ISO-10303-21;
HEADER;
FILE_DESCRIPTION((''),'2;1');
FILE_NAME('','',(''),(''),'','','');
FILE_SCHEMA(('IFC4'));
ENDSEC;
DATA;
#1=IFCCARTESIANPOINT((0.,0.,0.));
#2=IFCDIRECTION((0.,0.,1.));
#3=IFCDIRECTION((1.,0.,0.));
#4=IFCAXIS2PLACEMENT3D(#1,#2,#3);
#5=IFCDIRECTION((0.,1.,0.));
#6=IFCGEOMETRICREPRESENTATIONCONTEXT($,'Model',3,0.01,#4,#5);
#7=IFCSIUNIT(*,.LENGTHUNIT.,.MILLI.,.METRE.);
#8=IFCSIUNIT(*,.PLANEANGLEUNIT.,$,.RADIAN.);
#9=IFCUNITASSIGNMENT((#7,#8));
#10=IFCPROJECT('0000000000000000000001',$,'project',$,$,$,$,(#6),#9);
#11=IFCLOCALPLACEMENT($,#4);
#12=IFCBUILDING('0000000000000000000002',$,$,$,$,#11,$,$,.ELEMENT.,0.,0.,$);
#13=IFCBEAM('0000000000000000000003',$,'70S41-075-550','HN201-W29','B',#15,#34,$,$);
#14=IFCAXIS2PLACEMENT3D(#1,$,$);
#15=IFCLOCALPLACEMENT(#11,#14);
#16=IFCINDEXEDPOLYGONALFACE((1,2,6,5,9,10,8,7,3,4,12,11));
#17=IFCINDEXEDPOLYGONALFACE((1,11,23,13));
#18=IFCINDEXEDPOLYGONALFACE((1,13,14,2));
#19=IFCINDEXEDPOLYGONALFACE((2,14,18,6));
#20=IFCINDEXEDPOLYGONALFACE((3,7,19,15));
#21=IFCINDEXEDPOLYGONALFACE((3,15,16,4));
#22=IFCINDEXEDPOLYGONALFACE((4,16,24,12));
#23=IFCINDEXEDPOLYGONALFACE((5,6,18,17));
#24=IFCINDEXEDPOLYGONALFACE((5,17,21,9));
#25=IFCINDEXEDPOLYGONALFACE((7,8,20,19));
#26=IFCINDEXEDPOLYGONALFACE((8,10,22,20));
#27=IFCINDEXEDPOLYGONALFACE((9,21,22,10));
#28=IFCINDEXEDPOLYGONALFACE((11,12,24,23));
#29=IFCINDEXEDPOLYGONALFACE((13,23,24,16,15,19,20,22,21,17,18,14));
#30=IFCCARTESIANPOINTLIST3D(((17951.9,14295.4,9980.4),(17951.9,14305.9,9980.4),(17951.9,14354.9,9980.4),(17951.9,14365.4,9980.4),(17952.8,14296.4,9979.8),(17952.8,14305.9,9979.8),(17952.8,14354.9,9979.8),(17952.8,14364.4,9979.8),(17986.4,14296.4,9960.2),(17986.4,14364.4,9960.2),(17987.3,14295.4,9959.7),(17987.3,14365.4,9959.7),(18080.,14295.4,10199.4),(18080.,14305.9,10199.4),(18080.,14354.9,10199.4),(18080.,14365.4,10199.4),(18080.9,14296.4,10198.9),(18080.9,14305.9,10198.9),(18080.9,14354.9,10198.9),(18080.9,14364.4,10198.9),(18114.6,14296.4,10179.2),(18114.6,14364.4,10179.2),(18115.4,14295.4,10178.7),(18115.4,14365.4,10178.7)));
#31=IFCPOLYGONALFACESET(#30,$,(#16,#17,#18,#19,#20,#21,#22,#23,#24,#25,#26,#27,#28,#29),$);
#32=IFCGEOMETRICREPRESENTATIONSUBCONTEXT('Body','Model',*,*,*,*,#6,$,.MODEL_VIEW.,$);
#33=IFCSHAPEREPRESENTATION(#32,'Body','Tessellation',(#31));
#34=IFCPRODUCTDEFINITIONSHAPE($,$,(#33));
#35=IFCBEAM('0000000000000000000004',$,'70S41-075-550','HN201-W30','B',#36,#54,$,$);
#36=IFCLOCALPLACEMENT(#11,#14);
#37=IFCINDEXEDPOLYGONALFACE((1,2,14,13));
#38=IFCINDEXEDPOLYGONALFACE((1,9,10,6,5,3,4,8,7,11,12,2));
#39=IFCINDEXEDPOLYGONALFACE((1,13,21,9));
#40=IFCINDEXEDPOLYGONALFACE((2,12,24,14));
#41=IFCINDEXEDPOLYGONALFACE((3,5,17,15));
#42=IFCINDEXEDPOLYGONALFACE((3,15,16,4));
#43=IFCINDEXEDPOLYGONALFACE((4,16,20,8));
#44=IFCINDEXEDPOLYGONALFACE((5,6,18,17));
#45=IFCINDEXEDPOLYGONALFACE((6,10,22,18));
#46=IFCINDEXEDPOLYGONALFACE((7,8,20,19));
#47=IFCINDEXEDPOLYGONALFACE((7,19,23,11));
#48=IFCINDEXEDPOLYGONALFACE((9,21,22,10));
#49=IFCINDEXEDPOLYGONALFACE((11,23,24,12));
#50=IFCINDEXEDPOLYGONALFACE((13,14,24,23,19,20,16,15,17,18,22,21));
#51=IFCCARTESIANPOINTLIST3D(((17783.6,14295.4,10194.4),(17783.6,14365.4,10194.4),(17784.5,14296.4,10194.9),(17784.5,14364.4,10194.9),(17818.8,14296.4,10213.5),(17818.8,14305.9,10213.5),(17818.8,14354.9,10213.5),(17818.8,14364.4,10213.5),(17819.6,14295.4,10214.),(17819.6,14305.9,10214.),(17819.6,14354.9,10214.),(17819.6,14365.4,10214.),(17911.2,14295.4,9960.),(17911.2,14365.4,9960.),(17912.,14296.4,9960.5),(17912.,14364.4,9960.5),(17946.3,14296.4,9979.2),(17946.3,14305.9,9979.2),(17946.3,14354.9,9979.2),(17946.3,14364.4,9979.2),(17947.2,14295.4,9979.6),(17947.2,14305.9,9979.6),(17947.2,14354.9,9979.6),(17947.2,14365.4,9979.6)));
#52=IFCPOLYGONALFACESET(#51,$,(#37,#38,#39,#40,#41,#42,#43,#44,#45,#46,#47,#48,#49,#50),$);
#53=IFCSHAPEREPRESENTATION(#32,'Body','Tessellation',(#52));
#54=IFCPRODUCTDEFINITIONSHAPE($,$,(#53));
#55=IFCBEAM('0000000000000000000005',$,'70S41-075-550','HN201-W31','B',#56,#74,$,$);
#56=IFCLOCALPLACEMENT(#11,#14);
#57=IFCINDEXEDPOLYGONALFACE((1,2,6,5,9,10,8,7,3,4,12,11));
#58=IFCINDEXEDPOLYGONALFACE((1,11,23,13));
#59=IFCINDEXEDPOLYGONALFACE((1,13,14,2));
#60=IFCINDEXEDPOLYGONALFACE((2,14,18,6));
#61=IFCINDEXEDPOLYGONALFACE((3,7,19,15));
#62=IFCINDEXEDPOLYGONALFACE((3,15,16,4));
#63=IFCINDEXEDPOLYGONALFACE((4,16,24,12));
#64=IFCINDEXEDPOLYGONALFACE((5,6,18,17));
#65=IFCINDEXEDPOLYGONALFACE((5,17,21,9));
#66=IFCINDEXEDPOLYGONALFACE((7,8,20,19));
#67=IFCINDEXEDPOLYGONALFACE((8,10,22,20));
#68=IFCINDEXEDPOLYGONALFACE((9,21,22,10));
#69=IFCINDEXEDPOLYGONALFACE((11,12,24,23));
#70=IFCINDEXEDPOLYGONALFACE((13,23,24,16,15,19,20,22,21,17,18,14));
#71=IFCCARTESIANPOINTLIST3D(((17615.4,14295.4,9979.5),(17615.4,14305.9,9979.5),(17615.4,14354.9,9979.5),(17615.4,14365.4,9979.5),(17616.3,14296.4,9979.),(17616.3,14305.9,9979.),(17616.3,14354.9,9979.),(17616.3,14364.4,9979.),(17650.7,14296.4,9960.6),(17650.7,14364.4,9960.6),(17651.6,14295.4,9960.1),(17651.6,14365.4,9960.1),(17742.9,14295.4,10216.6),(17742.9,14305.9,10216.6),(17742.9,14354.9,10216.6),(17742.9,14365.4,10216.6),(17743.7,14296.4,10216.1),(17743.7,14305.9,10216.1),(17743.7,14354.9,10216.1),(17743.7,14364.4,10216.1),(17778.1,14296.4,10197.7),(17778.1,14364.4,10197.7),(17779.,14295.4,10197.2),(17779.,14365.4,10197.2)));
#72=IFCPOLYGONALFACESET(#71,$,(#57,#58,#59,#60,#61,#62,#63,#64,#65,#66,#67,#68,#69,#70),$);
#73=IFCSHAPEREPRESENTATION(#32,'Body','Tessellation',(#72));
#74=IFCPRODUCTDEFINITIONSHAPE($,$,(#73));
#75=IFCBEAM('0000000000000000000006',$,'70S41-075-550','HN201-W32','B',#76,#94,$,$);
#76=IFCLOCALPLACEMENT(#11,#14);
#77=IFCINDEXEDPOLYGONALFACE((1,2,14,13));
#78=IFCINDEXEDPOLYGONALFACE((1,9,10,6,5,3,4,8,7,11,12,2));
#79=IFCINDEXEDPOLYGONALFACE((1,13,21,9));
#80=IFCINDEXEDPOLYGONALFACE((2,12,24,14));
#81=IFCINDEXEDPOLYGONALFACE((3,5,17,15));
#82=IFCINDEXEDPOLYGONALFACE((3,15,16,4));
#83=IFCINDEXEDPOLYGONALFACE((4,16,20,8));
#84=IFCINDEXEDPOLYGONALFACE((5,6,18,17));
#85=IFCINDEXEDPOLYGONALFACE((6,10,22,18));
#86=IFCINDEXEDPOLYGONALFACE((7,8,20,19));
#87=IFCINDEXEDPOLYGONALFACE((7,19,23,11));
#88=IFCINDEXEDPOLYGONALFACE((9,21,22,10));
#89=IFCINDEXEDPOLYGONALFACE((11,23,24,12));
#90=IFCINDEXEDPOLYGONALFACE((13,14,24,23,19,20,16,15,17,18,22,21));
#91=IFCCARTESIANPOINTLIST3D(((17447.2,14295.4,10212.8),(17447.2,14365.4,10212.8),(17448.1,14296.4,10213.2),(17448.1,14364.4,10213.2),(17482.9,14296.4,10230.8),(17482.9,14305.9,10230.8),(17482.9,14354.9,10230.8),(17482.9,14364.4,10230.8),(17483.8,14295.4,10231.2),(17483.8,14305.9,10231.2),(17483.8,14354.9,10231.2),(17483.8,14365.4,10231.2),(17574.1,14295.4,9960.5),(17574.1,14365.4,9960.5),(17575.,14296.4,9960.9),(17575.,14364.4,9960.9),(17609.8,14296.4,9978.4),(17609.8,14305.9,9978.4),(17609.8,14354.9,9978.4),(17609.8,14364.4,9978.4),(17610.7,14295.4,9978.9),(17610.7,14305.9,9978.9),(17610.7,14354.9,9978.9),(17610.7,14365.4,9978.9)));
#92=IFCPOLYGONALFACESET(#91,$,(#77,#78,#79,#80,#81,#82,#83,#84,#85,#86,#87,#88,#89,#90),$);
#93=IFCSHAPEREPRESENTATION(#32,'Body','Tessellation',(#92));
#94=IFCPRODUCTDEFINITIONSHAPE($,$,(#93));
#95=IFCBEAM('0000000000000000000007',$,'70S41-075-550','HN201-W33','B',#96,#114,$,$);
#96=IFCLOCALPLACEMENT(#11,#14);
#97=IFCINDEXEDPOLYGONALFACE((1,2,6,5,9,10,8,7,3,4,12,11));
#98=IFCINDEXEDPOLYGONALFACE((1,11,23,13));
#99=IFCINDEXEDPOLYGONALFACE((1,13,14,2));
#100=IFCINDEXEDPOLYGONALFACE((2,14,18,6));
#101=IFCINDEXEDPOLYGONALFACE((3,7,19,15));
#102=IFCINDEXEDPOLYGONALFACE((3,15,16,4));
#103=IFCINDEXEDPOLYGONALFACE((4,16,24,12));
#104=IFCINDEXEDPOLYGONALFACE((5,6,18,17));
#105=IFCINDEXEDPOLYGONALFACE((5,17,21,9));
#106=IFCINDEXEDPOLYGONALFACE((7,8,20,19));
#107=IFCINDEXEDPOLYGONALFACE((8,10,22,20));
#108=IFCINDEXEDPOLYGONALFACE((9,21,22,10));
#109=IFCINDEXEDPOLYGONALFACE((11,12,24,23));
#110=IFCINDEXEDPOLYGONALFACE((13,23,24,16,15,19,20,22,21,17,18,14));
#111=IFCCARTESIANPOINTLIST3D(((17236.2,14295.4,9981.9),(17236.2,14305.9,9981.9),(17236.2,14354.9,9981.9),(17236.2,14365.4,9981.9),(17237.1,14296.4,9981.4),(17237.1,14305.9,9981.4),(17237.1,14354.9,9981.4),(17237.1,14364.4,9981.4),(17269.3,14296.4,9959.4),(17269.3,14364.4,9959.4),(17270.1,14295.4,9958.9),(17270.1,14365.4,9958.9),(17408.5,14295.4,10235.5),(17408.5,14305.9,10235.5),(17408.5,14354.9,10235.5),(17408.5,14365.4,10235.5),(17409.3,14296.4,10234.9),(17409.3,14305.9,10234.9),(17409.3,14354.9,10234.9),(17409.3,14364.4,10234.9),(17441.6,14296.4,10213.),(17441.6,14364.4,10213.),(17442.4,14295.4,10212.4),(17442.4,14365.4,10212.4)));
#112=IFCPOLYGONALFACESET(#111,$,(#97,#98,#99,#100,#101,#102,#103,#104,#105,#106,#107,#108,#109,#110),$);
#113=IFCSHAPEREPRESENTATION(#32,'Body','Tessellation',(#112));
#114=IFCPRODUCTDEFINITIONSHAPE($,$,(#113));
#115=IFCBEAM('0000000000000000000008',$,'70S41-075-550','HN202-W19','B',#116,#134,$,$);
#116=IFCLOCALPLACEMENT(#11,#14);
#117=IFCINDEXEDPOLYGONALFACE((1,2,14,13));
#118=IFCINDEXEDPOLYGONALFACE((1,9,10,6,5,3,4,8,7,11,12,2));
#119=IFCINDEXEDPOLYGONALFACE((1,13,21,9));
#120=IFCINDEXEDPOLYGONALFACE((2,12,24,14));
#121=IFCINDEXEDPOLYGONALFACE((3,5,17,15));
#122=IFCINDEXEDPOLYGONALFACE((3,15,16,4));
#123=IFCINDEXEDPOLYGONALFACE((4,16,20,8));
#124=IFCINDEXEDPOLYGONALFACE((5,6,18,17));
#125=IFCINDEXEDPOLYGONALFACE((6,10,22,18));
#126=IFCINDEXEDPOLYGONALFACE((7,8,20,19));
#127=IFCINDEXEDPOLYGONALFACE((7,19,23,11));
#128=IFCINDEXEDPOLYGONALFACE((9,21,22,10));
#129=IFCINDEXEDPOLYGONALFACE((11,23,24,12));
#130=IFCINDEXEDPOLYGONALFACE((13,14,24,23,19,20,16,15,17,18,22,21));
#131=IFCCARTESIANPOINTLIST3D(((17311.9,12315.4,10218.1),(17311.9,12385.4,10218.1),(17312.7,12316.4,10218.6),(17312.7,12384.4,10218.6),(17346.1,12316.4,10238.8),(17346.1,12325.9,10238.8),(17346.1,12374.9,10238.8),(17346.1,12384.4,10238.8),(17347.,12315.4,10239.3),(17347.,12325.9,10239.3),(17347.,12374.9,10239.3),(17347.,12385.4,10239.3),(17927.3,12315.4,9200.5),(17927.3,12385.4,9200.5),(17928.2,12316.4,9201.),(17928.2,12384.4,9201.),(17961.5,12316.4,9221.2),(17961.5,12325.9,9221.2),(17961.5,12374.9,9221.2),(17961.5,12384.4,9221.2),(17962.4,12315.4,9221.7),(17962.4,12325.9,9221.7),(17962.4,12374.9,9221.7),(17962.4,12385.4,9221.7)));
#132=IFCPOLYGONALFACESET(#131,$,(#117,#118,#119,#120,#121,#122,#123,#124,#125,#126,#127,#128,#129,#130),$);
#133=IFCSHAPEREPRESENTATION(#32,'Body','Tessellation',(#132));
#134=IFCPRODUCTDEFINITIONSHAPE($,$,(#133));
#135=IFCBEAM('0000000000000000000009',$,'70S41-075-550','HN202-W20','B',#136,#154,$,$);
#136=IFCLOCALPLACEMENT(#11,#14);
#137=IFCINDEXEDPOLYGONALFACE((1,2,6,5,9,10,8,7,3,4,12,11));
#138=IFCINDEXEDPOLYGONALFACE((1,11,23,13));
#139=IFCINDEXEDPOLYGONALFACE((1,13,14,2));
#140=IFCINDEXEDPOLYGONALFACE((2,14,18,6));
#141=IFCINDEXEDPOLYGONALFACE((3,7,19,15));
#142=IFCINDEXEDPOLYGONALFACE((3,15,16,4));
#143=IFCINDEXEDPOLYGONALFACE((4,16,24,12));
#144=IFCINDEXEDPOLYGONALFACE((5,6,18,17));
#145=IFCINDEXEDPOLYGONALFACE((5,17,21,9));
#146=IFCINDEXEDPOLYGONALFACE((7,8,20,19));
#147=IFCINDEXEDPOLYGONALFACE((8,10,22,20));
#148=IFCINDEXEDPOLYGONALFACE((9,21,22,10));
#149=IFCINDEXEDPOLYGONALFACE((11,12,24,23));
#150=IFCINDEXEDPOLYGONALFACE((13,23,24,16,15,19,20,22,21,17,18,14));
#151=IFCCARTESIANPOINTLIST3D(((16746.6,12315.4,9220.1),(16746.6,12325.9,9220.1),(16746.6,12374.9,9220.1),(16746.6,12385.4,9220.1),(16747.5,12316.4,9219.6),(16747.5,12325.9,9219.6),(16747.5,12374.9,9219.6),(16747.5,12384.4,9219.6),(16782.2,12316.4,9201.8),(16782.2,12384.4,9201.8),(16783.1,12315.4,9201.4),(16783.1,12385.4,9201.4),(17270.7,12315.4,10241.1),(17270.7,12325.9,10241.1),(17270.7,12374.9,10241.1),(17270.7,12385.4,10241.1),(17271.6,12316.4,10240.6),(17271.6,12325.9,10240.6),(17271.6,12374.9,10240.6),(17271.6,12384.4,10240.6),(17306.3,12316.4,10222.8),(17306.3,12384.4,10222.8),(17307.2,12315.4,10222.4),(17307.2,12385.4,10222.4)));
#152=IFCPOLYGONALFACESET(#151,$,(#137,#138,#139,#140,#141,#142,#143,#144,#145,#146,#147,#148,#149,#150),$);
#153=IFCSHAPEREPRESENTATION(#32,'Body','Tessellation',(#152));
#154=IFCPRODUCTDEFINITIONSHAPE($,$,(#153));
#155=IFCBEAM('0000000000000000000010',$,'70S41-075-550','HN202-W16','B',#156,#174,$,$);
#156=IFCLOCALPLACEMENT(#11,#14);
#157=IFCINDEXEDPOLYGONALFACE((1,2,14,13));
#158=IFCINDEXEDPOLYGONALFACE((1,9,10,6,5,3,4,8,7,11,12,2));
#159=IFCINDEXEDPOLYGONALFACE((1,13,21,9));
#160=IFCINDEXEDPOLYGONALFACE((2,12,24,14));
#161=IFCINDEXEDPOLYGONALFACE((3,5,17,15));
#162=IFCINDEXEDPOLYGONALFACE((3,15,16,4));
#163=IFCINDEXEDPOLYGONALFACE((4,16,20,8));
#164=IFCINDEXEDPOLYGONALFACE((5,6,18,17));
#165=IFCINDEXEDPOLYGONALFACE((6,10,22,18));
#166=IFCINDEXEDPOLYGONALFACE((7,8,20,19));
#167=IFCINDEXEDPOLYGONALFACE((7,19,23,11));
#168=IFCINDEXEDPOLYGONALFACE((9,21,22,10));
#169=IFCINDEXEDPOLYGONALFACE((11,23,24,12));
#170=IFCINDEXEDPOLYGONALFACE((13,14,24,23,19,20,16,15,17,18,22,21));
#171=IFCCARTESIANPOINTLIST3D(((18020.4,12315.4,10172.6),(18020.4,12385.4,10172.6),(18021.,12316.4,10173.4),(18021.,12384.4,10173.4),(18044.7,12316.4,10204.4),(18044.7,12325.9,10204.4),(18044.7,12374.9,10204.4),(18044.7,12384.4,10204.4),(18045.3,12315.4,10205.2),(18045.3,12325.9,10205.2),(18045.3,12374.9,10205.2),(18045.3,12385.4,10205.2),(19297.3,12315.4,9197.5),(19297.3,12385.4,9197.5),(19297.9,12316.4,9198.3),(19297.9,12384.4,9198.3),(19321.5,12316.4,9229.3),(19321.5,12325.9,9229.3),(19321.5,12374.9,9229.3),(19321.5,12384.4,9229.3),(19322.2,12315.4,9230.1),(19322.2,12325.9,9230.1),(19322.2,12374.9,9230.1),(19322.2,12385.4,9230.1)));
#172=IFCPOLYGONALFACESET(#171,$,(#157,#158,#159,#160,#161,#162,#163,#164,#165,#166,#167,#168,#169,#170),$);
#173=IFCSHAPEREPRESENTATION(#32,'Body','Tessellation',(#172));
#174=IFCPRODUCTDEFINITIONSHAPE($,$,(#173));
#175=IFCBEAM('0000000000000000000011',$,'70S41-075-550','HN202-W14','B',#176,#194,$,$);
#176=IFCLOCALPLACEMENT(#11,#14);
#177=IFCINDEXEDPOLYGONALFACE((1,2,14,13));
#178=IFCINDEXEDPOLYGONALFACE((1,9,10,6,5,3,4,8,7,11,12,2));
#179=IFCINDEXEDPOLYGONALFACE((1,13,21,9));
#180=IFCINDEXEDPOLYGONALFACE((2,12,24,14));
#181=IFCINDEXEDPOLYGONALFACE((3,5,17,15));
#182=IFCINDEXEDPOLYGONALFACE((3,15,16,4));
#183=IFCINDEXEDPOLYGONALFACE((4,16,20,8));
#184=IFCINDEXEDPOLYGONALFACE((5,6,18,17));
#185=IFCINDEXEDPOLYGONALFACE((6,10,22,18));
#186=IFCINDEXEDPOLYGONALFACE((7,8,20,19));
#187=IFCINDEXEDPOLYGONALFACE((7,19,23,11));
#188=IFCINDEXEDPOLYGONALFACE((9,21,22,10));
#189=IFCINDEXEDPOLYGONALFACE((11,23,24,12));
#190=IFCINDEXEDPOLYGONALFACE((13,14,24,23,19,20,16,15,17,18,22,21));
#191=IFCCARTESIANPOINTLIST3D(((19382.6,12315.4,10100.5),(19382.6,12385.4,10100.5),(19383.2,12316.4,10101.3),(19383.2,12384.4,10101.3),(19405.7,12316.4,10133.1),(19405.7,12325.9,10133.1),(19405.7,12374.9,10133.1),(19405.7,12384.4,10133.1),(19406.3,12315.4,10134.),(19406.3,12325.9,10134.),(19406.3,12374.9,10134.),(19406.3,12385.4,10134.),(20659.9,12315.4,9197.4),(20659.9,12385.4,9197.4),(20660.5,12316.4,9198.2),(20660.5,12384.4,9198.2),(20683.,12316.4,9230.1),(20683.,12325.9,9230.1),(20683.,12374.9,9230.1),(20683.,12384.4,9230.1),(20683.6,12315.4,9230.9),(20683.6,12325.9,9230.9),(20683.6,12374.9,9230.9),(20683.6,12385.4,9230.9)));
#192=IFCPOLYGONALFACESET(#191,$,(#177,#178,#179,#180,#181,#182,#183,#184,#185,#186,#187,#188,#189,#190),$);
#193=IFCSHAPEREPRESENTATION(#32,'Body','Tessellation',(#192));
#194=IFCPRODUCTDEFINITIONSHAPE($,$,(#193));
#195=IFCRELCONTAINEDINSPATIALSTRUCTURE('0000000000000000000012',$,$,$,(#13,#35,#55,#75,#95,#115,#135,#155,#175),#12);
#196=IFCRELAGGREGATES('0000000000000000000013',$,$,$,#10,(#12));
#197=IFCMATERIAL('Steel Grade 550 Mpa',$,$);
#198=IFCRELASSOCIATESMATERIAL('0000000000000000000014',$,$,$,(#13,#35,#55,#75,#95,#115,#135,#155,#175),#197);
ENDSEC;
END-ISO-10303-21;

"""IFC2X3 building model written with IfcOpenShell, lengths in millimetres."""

from ifc_helpers import new_model, si_unit, direction, frame, origin, origin_with_axes, origin_2d_with_axis, place, context, subcontext, project, spatial, c_section, extrude, source, transform, mapped, material, element, save


model = new_model("IFC2X3")

# Units and contexts
model_context = context("Model", 3, precision=0.01, world=origin_with_axes(), true_north=direction((0.0, 1.0, 0.0)))
body_context = subcontext(model_context, "Body", "Model", "MODEL_VIEW")
ifc_project = project(units=[si_unit("LENGTHUNIT", "METRE", prefix="MILLI"), si_unit("PLANEANGLEUNIT", "RADIAN")], contexts=[model_context])

# Building
building_placement = place(None, origin_with_axes())
building = spatial("IfcBuilding", under=ifc_project, at=building_placement, CompositionType="ELEMENT", ElevationOfRefHeight=0.0, ElevationOfTerrain=0.0)

# Shared definitions
ifc_material = material(Name="Steel Grade 550 Mpa")

# Beams
shared_shape_1 = source(origin(), body_context, "Body", "SweptSolid", [
    extrude(c_section(Depth=70.0, Width=41.0, WallThickness=1.0, Girth=10.5, at=origin_2d_with_axis()), origin_with_axes(), (0.0, 0.0, 1.0), 253.8),
])
beam_1_placement = place(None, frame((18097.7, 14330.4, 10189.1), z_axis=(-0.504813, 0.0, -0.863229), x_axis=(-0.863229, 0.0, 0.504813)))
element("IfcBeam", 1, at=beam_1_placement, inside=building, material=ifc_material, Name="70S41-075-550", Description="HN201-W29", ObjectType="B", context=body_context, shape_type="MappedRepresentation", body=[
    mapped(shared_shape_1, transform((0.0, 0.0, 0.0), scale=1.0)),
])
shared_shape_2 = source(origin(), body_context, "Body", "SweptSolid", [
    extrude(c_section(Depth=70.0, Width=41.0, WallThickness=1.0, Girth=10.5, at=origin_2d_with_axis()), origin_with_axes(), (0.0, 0.0, 1.0), 266.8),
])
beam_2_placement = place(None, frame((17929.2, 14330.4, 9969.8), z_axis=(-0.477961, 0.0, 0.878381), x_axis=(0.878381, 0.0, 0.477961)))
element("IfcBeam", 2, at=beam_2_placement, inside=building, material=ifc_material, Name="70S41-075-550", Description="HN201-W30", ObjectType="B", context=body_context, shape_type="MappedRepresentation", body=[
    mapped(shared_shape_2, transform((0.0, 0.0, 0.0), scale=1.0)),
])
shared_shape_3 = source(origin(), body_context, "Body", "SweptSolid", [
    extrude(c_section(Depth=70.0, Width=41.0, WallThickness=1.0, Girth=10.5, at=origin_2d_with_axis()), origin_with_axes(), (0.0, 0.0, 1.0), 269.2),
])
beam_3_placement = place(None, frame((17760.9, 14330.4, 10206.9), z_axis=(-0.473399, 0.0, -0.880848), x_axis=(-0.880848, 0.0, 0.473399)))
element("IfcBeam", 3, at=beam_3_placement, inside=building, material=ifc_material, Name="70S41-075-550", Description="HN201-W31", ObjectType="B", context=body_context, shape_type="MappedRepresentation", body=[
    mapped(shared_shape_3, transform((0.0, 0.0, 0.0), scale=1.0)),
])
shared_shape_4 = source(origin(), body_context, "Body", "SweptSolid", [
    extrude(c_section(Depth=70.0, Width=41.0, WallThickness=1.0, Girth=10.5, at=origin_2d_with_axis()), origin_with_axes(), (0.0, 0.0, 1.0), 282.4),
])
beam_4_placement = place(None, frame((17592.4, 14330.4, 9969.7), z_axis=(-0.449286, 0.0, 0.893388), x_axis=(0.893388, 0.0, 0.449286)))
element("IfcBeam", 4, at=beam_4_placement, inside=building, material=ifc_material, Name="70S41-075-550", Description="HN201-W32", ObjectType="B", context=body_context, shape_type="MappedRepresentation", body=[
    mapped(shared_shape_4, transform((0.0, 0.0, 0.0), scale=1.0)),
])
shared_shape_5 = source(origin(), body_context, "Body", "SweptSolid", [
    extrude(c_section(Depth=70.0, Width=41.0, WallThickness=1.0, Girth=10.5, at=origin_2d_with_axis()), origin_with_axes(), (0.0, 0.0, 1.0), 306.5),
])
beam_5_placement = place(None, frame((17425.4, 14330.4, 10224.0), z_axis=(-0.561957, 0.0, -0.827166), x_axis=(-0.827166, 0.0, 0.561957)))
element("IfcBeam", 5, at=beam_5_placement, inside=building, material=ifc_material, Name="70S41-075-550", Description="HN201-W33", ObjectType="B", context=body_context, shape_type="MappedRepresentation", body=[
    mapped(shared_shape_5, transform((0.0, 0.0, 0.0), scale=1.0)),
])
shared_shape_6 = source(origin(), body_context, "Body", "SweptSolid", [
    extrude(c_section(Depth=70.0, Width=41.0, WallThickness=1.0, Girth=10.5, at=origin_2d_with_axis()), origin_with_axes(), (0.0, 0.0, 1.0), 1189.2),
])
beam_6_placement = place(None, frame((17944.9, 12350.4, 9211.1), z_axis=(-0.517517, 0.0, 0.855673), x_axis=(0.855673, 0.0, 0.517517)))
element("IfcBeam", 6, at=beam_6_placement, inside=building, material=ifc_material, Name="70S41-075-550", Description="HN202-W19", ObjectType="B", context=body_context, shape_type="MappedRepresentation", body=[
    mapped(shared_shape_6, transform((0.0, 0.0, 0.0), scale=1.0)),
])
shared_shape_7 = source(origin(), body_context, "Body", "SweptSolid", [
    extrude(c_section(Depth=70.0, Width=41.0, WallThickness=1.0, Girth=10.5, at=origin_2d_with_axis()), origin_with_axes(), (0.0, 0.0, 1.0), 1147.7),
])
beam_7_placement = place(None, frame((17289.0, 12350.4, 10231.7), z_axis=(-0.456666, 0.0, -0.889638), x_axis=(-0.889638, 0.0, 0.456666)))
element("IfcBeam", 7, at=beam_7_placement, inside=building, material=ifc_material, Name="70S41-075-550", Description="HN202-W20", ObjectType="B", context=body_context, shape_type="MappedRepresentation", body=[
    mapped(shared_shape_7, transform((0.0, 0.0, 0.0), scale=1.0)),
])
shared_shape_8 = source(origin(), body_context, "Body", "SweptSolid", [
    extrude(c_section(Depth=70.0, Width=41.0, WallThickness=1.0, Girth=10.5, at=origin_2d_with_axis()), origin_with_axes(), (0.0, 0.0, 1.0), 1606.6),
])
beam_8_placement = place(None, frame((19309.7, 12350.4, 9213.8), z_axis=(-0.794756, 0.0, 0.606929), x_axis=(0.606929, 0.0, 0.794756)))
element("IfcBeam", 8, at=beam_8_placement, inside=building, material=ifc_material, Name="70S41-075-550", Description="HN202-W16", ObjectType="B", context=body_context, shape_type="MappedRepresentation", body=[
    mapped(shared_shape_8, transform((0.0, 0.0, 0.0), scale=1.0)),
])
shared_shape_9 = source(origin(), body_context, "Body", "SweptSolid", [
    extrude(c_section(Depth=70.0, Width=41.0, WallThickness=1.0, Girth=10.5, at=origin_2d_with_axis()), origin_with_axes(), (0.0, 0.0, 1.0), 1564.3),
])
beam_9_placement = place(None, frame((20671.8, 12350.4, 9214.1), z_axis=(-0.816539, 0.0, 0.57729), x_axis=(0.57729, 0.0, 0.816539)))
element("IfcBeam", 9, at=beam_9_placement, inside=building, material=ifc_material, Name="70S41-075-550", Description="HN202-W14", ObjectType="B", context=body_context, shape_type="MappedRepresentation", body=[
    mapped(shared_shape_9, transform((0.0, 0.0, 0.0), scale=1.0)),
])

save(model, "model.ifc")
